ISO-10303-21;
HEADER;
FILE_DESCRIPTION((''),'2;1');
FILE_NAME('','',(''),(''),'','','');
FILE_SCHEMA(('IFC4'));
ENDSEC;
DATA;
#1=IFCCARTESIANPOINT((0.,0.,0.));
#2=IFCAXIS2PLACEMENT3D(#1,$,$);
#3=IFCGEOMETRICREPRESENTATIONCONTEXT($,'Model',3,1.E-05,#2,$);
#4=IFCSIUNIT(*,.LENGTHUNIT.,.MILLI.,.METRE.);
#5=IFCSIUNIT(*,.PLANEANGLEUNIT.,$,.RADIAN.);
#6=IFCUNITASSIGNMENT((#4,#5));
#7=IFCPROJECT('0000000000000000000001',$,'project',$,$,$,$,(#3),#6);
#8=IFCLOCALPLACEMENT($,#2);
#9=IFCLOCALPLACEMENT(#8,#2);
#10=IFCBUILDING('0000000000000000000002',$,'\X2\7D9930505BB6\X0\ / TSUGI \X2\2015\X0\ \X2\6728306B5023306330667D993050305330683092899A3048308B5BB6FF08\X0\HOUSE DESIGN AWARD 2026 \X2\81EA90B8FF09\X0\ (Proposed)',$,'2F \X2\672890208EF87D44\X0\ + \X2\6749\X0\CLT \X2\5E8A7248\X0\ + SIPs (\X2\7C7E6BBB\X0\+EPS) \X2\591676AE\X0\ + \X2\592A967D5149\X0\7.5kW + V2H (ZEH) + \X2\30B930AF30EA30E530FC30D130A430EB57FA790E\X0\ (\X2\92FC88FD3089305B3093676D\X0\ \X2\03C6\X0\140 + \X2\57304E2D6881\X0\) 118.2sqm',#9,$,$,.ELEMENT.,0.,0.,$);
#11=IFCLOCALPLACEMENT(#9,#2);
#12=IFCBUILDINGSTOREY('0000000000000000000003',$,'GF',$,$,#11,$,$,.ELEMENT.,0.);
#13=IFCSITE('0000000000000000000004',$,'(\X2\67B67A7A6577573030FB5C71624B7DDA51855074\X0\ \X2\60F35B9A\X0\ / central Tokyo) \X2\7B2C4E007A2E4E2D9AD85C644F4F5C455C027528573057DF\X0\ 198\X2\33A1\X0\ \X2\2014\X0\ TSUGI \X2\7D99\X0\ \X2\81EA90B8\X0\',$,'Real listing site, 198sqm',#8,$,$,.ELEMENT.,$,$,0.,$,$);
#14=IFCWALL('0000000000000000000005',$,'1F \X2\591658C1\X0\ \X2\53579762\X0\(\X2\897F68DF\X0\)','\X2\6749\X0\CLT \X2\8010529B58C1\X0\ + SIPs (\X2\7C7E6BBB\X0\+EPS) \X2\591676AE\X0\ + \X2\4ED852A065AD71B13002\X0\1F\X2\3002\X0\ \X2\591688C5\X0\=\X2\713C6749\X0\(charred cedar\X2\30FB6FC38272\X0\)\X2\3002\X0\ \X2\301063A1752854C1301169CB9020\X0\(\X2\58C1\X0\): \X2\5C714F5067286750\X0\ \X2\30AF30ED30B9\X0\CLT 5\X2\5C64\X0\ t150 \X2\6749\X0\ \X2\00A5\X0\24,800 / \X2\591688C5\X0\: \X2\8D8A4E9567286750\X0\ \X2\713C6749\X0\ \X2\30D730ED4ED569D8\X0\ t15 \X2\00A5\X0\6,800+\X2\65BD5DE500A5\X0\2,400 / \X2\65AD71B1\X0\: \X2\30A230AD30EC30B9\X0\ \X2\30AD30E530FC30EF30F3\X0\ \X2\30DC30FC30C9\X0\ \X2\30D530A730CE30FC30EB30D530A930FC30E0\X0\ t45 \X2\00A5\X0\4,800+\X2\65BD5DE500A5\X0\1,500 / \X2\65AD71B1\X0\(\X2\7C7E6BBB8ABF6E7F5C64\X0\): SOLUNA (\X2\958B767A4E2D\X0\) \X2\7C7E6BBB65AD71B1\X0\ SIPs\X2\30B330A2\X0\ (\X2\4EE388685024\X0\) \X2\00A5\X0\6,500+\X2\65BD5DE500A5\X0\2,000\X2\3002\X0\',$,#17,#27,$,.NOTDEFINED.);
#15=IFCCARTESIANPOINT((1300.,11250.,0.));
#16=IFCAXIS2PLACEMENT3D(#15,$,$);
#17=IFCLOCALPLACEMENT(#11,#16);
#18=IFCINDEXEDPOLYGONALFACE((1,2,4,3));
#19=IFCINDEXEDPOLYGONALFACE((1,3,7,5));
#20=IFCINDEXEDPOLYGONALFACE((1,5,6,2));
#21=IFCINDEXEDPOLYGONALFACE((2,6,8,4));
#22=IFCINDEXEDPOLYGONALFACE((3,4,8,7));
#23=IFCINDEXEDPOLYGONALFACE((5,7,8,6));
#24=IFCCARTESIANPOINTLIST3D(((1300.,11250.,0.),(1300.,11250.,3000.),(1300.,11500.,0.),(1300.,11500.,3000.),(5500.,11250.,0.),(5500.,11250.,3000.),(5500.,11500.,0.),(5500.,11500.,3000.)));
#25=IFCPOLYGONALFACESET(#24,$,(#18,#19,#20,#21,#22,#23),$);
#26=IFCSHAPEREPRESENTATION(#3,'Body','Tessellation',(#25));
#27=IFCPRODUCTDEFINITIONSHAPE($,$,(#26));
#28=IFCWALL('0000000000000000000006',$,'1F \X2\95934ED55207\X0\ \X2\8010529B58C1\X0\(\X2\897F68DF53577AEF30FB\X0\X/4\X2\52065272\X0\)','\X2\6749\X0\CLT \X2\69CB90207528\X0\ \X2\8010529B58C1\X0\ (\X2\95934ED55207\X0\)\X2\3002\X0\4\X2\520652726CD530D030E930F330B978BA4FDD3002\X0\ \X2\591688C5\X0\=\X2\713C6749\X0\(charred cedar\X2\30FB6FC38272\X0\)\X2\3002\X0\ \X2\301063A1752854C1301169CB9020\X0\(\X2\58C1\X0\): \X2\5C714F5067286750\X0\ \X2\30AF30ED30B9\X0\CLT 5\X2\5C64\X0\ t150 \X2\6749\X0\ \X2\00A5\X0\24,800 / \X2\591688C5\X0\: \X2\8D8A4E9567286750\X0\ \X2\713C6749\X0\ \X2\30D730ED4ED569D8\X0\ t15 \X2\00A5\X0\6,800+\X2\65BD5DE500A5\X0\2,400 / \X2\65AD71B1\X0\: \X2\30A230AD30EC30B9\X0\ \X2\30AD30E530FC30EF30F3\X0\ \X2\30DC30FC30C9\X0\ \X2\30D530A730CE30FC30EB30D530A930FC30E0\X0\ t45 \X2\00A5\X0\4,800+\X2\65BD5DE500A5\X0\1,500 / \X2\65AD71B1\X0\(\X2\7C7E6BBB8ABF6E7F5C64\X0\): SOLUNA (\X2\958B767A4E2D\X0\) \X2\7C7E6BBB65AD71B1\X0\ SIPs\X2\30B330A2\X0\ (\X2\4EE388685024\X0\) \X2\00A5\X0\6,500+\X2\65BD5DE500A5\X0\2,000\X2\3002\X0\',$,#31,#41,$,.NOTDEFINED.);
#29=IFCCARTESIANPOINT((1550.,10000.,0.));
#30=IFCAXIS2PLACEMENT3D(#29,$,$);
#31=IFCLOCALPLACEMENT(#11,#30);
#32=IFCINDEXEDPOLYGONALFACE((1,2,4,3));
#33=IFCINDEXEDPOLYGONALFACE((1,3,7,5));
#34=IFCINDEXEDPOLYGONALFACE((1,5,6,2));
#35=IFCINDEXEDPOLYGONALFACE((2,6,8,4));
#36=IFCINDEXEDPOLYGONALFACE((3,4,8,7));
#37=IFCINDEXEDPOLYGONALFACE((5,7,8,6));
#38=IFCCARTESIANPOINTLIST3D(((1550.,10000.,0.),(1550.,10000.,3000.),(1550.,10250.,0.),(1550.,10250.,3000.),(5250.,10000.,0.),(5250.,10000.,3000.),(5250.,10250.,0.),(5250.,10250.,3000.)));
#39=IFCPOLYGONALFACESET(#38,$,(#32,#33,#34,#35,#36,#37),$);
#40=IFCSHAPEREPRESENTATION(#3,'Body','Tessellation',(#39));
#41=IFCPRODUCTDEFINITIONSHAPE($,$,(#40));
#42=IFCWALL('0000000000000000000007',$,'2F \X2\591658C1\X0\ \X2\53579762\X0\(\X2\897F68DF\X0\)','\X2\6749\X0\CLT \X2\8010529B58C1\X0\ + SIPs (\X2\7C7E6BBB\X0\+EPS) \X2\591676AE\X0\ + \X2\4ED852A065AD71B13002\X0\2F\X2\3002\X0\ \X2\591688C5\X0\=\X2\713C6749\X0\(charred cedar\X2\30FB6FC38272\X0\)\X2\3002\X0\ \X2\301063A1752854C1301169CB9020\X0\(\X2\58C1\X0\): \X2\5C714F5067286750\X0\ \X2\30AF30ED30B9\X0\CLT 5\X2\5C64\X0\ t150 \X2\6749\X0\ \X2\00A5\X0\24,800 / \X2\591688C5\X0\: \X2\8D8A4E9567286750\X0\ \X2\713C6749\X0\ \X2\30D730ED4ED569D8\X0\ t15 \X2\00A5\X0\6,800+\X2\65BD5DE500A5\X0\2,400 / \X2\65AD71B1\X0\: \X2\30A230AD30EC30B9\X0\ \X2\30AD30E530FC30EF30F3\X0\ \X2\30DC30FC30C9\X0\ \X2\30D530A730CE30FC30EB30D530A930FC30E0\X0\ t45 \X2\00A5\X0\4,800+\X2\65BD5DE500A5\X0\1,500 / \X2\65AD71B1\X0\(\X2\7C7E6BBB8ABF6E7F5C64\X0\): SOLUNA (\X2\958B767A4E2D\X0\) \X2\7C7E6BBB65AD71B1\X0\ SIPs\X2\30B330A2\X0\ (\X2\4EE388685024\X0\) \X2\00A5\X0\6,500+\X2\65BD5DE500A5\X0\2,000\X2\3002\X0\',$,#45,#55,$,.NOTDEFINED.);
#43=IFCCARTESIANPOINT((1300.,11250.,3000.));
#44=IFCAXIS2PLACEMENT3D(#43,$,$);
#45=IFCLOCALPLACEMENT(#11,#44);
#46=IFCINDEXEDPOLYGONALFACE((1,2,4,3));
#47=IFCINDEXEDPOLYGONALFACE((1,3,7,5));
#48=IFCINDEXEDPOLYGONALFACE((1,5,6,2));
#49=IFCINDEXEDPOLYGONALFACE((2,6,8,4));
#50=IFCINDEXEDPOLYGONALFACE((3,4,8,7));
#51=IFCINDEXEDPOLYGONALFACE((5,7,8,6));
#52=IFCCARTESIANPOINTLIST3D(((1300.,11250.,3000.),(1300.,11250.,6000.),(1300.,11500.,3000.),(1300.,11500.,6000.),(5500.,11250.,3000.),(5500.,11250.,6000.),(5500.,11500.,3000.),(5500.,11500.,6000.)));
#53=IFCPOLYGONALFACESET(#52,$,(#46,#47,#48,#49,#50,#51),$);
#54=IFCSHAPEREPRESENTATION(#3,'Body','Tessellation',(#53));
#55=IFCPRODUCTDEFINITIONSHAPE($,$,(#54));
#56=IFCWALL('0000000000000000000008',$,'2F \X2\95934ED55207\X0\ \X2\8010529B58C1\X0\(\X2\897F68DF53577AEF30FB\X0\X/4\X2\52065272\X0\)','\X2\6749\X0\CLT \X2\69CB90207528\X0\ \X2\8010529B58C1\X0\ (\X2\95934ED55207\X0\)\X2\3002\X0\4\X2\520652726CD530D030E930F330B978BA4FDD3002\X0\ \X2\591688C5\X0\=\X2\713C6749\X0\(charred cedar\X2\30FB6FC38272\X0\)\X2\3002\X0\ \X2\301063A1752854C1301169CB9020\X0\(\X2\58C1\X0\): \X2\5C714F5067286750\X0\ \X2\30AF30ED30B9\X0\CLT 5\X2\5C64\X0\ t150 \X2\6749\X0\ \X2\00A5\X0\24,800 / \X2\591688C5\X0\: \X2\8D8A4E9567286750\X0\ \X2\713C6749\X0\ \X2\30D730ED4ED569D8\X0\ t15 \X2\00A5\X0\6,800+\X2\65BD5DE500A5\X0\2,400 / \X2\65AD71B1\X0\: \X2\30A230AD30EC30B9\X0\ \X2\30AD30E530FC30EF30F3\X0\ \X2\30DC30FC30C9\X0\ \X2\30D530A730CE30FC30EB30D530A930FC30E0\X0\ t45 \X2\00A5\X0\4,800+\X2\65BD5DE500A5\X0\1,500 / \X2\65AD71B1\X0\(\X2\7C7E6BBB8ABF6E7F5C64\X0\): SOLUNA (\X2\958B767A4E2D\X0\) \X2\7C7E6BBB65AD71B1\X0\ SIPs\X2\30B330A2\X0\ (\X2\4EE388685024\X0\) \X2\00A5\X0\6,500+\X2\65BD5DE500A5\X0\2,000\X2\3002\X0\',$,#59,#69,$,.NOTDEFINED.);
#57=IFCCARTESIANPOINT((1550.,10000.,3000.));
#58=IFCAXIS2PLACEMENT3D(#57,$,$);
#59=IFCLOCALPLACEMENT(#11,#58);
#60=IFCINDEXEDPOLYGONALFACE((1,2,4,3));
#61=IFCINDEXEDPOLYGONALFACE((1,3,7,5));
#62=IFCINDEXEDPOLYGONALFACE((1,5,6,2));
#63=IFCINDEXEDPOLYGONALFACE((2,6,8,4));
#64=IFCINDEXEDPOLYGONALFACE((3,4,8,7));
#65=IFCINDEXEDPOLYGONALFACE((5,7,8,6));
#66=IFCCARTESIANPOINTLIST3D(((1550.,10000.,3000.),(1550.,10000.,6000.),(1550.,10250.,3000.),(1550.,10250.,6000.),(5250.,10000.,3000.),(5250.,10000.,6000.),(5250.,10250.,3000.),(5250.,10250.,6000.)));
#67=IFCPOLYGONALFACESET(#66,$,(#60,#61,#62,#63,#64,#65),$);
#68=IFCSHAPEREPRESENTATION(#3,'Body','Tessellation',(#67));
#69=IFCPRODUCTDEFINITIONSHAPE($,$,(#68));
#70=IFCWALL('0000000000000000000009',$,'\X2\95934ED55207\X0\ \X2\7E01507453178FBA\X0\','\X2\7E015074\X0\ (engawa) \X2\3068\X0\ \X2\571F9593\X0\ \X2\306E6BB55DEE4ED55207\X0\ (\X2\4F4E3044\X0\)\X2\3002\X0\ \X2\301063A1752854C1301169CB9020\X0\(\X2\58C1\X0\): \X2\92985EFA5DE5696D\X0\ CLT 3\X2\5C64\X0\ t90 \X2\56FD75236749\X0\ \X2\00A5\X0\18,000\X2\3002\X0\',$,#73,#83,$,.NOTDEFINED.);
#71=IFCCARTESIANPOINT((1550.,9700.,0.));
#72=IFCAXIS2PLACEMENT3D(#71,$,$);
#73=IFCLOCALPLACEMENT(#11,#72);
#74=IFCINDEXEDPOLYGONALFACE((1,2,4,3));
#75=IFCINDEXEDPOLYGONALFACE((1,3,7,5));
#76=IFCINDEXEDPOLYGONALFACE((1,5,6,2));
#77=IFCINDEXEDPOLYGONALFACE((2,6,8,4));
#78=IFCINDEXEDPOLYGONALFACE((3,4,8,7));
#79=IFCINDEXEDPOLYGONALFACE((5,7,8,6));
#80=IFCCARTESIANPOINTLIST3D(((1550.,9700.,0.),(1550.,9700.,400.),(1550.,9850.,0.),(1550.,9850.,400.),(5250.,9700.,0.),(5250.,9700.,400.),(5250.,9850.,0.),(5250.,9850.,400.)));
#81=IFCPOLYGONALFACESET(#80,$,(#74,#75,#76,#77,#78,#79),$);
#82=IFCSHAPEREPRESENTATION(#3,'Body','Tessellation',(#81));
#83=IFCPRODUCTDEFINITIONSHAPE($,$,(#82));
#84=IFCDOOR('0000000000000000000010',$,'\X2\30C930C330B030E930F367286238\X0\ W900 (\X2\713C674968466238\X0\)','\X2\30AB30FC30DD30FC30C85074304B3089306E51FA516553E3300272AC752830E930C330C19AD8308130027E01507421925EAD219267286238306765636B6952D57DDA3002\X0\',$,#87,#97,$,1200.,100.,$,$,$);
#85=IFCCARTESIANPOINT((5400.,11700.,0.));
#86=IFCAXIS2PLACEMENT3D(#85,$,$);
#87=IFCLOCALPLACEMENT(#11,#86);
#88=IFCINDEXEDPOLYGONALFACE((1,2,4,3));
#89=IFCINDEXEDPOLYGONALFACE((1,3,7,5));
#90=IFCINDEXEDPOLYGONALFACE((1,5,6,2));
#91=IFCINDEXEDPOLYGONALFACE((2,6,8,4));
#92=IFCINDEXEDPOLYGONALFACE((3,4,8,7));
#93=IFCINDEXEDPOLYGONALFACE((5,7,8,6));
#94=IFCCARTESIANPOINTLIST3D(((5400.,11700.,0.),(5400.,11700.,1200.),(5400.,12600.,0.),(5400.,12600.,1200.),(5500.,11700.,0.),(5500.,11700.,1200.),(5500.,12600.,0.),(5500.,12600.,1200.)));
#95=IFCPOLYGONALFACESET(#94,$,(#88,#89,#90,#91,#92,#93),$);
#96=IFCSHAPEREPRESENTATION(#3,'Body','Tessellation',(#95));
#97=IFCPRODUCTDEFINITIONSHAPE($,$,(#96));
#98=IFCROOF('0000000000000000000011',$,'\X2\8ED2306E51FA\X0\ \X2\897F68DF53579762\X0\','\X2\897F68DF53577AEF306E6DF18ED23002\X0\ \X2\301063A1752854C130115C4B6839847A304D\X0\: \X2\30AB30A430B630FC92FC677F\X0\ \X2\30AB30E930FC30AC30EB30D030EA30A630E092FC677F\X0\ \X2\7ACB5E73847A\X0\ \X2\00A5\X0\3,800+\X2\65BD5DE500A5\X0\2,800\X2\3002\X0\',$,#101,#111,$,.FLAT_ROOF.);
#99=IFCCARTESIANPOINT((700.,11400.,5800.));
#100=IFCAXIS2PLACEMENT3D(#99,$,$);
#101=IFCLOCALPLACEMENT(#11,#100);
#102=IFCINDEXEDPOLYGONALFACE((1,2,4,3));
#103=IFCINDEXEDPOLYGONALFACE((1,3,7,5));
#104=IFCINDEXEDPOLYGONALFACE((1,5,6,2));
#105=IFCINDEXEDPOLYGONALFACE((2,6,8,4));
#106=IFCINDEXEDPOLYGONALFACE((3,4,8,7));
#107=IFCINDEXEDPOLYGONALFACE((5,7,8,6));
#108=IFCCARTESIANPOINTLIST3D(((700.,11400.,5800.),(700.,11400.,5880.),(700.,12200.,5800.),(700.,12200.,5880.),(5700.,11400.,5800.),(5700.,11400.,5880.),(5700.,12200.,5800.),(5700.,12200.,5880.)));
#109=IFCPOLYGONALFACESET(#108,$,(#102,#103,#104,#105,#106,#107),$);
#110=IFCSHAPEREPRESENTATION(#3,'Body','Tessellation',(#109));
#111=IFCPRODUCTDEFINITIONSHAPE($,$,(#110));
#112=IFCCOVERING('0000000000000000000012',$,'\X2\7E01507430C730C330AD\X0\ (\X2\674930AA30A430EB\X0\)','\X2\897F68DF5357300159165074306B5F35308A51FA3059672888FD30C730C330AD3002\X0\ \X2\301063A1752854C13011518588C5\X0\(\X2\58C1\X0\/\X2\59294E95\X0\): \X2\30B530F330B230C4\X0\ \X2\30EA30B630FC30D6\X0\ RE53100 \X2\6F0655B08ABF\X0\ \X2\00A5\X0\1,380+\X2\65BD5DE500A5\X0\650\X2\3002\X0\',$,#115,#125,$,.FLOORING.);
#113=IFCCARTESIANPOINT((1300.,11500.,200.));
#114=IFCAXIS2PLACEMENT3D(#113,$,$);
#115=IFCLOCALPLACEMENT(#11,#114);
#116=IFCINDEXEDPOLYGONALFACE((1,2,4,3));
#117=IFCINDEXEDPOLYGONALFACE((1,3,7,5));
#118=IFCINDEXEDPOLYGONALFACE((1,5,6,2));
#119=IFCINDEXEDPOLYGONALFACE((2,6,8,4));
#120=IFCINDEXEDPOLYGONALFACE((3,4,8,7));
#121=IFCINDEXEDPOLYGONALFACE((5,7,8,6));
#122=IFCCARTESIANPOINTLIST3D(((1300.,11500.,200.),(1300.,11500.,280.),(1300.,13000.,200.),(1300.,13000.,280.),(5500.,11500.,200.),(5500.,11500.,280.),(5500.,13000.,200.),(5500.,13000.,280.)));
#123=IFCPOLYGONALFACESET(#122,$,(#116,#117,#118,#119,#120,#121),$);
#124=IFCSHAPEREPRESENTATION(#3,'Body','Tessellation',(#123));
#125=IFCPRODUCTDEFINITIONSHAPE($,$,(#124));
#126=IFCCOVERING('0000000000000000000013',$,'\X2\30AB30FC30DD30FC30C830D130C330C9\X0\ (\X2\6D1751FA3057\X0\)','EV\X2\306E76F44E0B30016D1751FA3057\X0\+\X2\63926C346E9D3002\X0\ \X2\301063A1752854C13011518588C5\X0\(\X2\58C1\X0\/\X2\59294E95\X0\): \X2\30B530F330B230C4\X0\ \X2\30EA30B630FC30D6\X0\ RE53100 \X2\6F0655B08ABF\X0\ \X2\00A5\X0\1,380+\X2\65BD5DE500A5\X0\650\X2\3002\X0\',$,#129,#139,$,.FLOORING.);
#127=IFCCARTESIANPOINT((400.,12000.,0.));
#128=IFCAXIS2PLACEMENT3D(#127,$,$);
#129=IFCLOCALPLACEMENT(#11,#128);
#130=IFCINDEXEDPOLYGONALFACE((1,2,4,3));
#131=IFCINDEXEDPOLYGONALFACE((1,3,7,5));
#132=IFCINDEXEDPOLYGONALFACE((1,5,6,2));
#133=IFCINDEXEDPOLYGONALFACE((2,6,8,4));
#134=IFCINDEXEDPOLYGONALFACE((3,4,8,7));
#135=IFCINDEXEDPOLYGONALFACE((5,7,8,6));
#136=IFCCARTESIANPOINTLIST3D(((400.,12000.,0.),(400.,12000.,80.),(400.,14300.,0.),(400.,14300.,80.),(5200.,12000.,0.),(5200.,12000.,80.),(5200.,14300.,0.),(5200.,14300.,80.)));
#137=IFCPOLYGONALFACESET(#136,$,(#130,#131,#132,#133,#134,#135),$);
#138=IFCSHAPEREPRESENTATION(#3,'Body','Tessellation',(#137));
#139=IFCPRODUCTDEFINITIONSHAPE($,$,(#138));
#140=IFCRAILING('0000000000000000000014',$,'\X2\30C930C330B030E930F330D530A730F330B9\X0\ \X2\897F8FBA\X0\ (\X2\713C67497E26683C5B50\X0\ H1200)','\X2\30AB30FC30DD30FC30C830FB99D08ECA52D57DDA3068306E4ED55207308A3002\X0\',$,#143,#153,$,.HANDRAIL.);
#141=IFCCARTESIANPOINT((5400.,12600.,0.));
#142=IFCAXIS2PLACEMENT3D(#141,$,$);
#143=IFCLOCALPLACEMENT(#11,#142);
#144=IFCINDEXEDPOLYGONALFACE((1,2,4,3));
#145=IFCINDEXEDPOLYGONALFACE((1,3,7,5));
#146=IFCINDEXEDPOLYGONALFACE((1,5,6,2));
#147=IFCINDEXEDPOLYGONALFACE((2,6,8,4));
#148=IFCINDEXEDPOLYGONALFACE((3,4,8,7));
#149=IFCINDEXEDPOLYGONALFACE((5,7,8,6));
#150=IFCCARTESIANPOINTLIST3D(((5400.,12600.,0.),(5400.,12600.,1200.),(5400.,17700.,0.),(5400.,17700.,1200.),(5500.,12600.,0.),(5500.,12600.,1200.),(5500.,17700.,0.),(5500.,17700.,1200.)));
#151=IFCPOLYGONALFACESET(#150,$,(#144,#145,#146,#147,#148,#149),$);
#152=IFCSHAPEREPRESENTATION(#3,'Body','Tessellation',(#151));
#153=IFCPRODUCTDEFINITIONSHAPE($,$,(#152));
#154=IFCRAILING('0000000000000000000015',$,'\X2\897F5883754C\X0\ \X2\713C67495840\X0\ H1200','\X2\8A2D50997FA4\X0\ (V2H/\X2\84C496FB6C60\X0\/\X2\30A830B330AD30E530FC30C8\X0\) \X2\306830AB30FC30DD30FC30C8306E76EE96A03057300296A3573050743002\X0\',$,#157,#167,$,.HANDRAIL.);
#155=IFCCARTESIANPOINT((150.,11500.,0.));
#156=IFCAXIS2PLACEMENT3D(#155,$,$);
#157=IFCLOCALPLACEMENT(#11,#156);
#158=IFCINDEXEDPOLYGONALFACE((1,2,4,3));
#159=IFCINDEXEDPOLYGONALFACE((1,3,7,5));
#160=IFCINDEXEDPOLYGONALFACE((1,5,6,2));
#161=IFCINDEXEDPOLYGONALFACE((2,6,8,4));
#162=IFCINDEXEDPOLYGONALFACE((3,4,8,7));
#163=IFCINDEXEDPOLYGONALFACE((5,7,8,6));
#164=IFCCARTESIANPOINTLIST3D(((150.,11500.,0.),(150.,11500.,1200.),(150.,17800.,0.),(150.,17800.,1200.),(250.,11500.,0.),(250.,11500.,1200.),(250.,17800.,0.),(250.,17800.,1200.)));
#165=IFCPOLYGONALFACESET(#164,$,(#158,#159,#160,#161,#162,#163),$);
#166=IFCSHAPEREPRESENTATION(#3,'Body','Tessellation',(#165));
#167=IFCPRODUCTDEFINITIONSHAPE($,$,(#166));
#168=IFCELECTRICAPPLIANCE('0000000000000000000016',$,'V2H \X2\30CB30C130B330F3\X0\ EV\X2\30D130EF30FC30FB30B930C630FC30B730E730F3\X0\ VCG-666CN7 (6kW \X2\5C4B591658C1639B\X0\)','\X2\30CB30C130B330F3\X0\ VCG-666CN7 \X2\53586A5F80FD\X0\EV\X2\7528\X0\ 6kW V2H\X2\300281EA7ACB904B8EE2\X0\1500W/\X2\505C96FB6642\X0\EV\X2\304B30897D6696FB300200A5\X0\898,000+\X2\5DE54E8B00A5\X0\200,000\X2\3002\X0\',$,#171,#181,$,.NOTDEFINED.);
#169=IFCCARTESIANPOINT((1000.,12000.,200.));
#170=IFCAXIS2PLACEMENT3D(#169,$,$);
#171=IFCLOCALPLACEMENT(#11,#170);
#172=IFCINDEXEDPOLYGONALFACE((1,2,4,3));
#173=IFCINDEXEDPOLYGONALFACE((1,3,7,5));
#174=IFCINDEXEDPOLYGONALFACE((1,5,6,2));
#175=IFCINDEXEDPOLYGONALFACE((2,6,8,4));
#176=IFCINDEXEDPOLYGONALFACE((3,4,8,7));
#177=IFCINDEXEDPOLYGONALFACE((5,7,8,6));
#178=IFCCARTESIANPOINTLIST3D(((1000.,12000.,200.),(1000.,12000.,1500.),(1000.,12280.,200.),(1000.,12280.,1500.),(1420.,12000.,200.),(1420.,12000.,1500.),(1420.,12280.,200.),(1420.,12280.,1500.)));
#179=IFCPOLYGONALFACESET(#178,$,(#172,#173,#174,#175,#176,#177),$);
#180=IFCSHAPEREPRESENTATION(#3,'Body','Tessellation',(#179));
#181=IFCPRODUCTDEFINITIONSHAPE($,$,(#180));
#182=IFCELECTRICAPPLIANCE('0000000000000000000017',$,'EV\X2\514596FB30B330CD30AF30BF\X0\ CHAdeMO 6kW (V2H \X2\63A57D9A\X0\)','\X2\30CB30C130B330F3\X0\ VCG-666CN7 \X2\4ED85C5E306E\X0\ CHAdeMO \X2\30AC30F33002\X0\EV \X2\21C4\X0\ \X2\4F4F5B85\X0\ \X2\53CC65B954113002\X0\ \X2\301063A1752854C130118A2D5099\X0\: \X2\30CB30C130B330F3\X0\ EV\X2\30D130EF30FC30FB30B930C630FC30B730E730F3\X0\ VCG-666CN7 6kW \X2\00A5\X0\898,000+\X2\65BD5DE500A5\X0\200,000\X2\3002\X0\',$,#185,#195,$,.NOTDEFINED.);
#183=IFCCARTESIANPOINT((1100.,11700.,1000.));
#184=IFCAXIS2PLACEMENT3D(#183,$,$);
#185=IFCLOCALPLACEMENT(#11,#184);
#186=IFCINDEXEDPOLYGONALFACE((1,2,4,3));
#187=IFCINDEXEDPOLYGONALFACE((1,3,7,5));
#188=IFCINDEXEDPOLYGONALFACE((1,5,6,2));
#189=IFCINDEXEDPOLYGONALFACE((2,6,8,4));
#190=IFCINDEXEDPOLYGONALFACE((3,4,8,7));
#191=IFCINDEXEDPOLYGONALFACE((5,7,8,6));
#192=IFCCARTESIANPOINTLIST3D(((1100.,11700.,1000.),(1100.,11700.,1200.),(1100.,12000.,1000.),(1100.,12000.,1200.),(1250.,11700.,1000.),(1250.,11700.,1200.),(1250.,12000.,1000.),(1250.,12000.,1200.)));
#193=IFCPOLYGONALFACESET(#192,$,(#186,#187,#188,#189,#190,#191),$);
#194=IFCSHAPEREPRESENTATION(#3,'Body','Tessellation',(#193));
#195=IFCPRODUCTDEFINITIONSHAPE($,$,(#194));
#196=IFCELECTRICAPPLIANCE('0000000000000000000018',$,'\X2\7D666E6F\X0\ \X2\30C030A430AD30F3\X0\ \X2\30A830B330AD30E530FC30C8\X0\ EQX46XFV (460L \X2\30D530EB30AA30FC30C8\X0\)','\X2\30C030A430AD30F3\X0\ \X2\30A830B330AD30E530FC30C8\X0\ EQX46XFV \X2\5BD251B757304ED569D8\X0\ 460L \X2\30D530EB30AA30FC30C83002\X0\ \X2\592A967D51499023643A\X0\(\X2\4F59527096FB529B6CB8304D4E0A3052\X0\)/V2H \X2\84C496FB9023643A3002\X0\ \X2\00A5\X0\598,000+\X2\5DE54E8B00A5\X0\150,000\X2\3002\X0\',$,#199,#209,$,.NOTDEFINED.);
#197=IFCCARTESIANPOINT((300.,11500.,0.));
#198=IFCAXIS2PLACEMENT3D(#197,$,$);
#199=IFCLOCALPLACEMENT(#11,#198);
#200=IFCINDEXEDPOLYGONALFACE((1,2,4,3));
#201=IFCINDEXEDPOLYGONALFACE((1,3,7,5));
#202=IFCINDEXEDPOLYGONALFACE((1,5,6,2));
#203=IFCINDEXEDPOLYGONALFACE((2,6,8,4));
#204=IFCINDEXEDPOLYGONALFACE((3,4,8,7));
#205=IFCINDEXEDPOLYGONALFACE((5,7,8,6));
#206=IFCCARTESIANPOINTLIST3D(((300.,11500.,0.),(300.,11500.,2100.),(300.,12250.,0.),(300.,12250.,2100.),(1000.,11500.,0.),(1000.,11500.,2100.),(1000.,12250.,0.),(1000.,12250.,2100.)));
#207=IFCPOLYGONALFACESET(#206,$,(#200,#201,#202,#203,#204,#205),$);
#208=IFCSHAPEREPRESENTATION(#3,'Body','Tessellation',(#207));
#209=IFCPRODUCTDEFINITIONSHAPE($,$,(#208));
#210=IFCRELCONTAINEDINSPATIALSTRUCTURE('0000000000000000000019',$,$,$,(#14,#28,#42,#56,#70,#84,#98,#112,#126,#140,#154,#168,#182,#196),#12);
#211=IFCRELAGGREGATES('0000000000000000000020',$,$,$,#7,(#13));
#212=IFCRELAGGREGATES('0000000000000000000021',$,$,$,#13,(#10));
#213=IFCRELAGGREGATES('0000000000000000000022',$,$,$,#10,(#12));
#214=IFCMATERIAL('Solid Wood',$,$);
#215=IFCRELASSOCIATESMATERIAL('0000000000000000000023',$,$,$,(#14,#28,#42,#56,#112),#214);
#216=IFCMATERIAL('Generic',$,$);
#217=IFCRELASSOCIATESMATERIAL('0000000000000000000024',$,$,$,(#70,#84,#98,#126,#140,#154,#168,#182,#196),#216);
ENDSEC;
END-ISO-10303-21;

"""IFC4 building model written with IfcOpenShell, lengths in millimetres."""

from ifc_helpers import new_model, si_unit, frame, frame_2d, origin, place, context, project, spatial, rectangle, extrude, material, element, save


model = new_model("IFC4")

# Units and contexts
model_context = context("Model", 3, precision=1e-05, world=origin())
ifc_project = project(units=[si_unit("LENGTHUNIT", "METRE", prefix="MILLI"), si_unit("PLANEANGLEUNIT", "RADIAN")], contexts=[model_context])

# Site, building, storey
site_placement = place(None, origin())
site = spatial("IfcSite", under=ifc_project, at=site_placement, Name="(架空敷地・山手線内側 想定 / central Tokyo) 第一種中高層住居専用地域 198㎡ — TSUGI 継 自邸", ObjectType="Real listing site, 198sqm", CompositionType="ELEMENT", RefElevation=0.0)
building_placement = place(site_placement, origin())
building = spatial("IfcBuilding", under=site, at=building_placement, Name="継ぐ家 / TSUGI ― 木に倣って継ぐことを覚える家（HOUSE DESIGN AWARD 2026 自邸） (Proposed)", ObjectType="2F 木造軸組 + 杉CLT 床版 + SIPs (籾殻+EPS) 外皮 + 太陽光7.5kW + V2H (ZEH) + スクリューパイル基礎 (鋼製らせん杭 φ140 + 地中梁) 118.2sqm", CompositionType="ELEMENT", ElevationOfRefHeight=0.0, ElevationOfTerrain=0.0)
storey_placement = place(building_placement, origin())
storey = spatial("IfcBuildingStorey", under=building, at=storey_placement, Name="GF", CompositionType="ELEMENT", Elevation=0.0)

# Shared definitions
ifc_material_1 = material(Name="Generic")

# Walls
ifc_material_2 = material(Name="Solid Wood")
wall_1_placement = place(storey_placement, frame((1300.0, 11250.0, 0.0)))
element("IfcWall", 1, at=wall_1_placement, inside=storey, material=ifc_material_2, Name="1F 外壁 南面(西棟)", Description="杉CLT 耐力壁 + SIPs (籾殻+EPS) 外皮 + 付加断熱。1F。 外装=焼杉(charred cedar・濃色)。 【採用品】構造(壁): 山佐木材 クロスCLT 5層 t150 杉 ¥24,800 / 外装: 越井木材 焼杉 プロ仕様 t15 ¥6,800+施工¥2,400 / 断熱: アキレス キューワン ボード フェノールフォーム t45 ¥4,800+施工¥1,500 / 断熱(籾殻調湿層): SOLUNA (開発中) 籾殻断熱 SIPsコア (代表値) ¥6,500+施工¥2,000。", PredefinedType="NOTDEFINED", context=model_context, shape_type="SweptSolid", body=[
    extrude(rectangle(XDim=4200.0, YDim=250.0, at=frame_2d((2100.0, 125.0))), frame((1300.0, 11250.0, 0.0)), (0.0, 0.0, 1.0), 3000.0),
])
wall_2_placement = place(storey_placement, frame((1550.0, 10000.0, 0.0)))
element("IfcWall", 2, at=wall_2_placement, inside=storey, material=ifc_material_2, Name="1F 間仕切 耐力壁(西棟南端・X/4分割)", Description="杉CLT 構造用 耐力壁 (間仕切)。4分割法バランス確保。 外装=焼杉(charred cedar・濃色)。 【採用品】構造(壁): 山佐木材 クロスCLT 5層 t150 杉 ¥24,800 / 外装: 越井木材 焼杉 プロ仕様 t15 ¥6,800+施工¥2,400 / 断熱: アキレス キューワン ボード フェノールフォーム t45 ¥4,800+施工¥1,500 / 断熱(籾殻調湿層): SOLUNA (開発中) 籾殻断熱 SIPsコア (代表値) ¥6,500+施工¥2,000。", PredefinedType="NOTDEFINED", context=model_context, shape_type="SweptSolid", body=[
    extrude(rectangle(XDim=3700.0, YDim=250.0, at=frame_2d((1850.0, 125.0))), frame((1550.0, 10000.0, 0.0)), (0.0, 0.0, 1.0), 3000.0),
])
wall_3_placement = place(storey_placement, frame((1300.0, 11250.0, 3000.0)))
element("IfcWall", 3, at=wall_3_placement, inside=storey, material=ifc_material_2, Name="2F 外壁 南面(西棟)", Description="杉CLT 耐力壁 + SIPs (籾殻+EPS) 外皮 + 付加断熱。2F。 外装=焼杉(charred cedar・濃色)。 【採用品】構造(壁): 山佐木材 クロスCLT 5層 t150 杉 ¥24,800 / 外装: 越井木材 焼杉 プロ仕様 t15 ¥6,800+施工¥2,400 / 断熱: アキレス キューワン ボード フェノールフォーム t45 ¥4,800+施工¥1,500 / 断熱(籾殻調湿層): SOLUNA (開発中) 籾殻断熱 SIPsコア (代表値) ¥6,500+施工¥2,000。", PredefinedType="NOTDEFINED", context=model_context, shape_type="SweptSolid", body=[
    extrude(rectangle(XDim=4200.0, YDim=250.0, at=frame_2d((2100.0, 125.0))), frame((1300.0, 11250.0, 3000.0)), (0.0, 0.0, 1.0), 3000.0),
])
wall_4_placement = place(storey_placement, frame((1550.0, 10000.0, 3000.0)))
element("IfcWall", 4, at=wall_4_placement, inside=storey, material=ifc_material_2, Name="2F 間仕切 耐力壁(西棟南端・X/4分割)", Description="杉CLT 構造用 耐力壁 (間仕切)。4分割法バランス確保。 外装=焼杉(charred cedar・濃色)。 【採用品】構造(壁): 山佐木材 クロスCLT 5層 t150 杉 ¥24,800 / 外装: 越井木材 焼杉 プロ仕様 t15 ¥6,800+施工¥2,400 / 断熱: アキレス キューワン ボード フェノールフォーム t45 ¥4,800+施工¥1,500 / 断熱(籾殻調湿層): SOLUNA (開発中) 籾殻断熱 SIPsコア (代表値) ¥6,500+施工¥2,000。", PredefinedType="NOTDEFINED", context=model_context, shape_type="SweptSolid", body=[
    extrude(rectangle(XDim=3700.0, YDim=250.0, at=frame_2d((1850.0, 125.0))), frame((1550.0, 10000.0, 3000.0)), (0.0, 0.0, 1.0), 3000.0),
])
wall_5_placement = place(storey_placement, frame((1550.0, 9700.0, 0.0)))
element("IfcWall", 5, at=wall_5_placement, inside=storey, material=ifc_material_1, Name="間仕切 縁側北辺", Description="縁側 (engawa) と 土間 の段差仕切 (低い)。 【採用品】構造(壁): 銘建工業 CLT 3層 t90 国産杉 ¥18,000。", PredefinedType="NOTDEFINED", context=model_context, shape_type="SweptSolid", body=[
    extrude(rectangle(XDim=3700.0, YDim=150.0, at=frame_2d((1850.0, 75.0))), frame((1550.0, 9700.0, 0.0)), (0.0, 0.0, 1.0), 400.0),
])

# Door
door_placement = place(storey_placement, frame((5400.0, 11700.0, 0.0)))
element("IfcDoor", 6, at=door_placement, inside=storey, material=ifc_material_1, Name="ドッグラン木戸 W900 (焼杉框戸)", Description="カーポート側からの出入口。犬用ラッチ高め。縁側→庭→木戸で散歩動線。", OverallHeight=1200.0, OverallWidth=100.0, context=model_context, shape_type="SweptSolid", body=[
    extrude(rectangle(XDim=100.0, YDim=900.0, at=frame_2d((50.0, 450.0))), frame((5400.0, 11700.0, 0.0)), (0.0, 0.0, 1.0), 1200.0),
])

# Roof
roof_placement = place(storey_placement, frame((700.0, 11400.0, 5800.0)))
element("IfcRoof", 7, at=roof_placement, inside=storey, material=ifc_material_1, Name="軒の出 西棟南面", Description="西棟南端の深軒。 【採用品】屋根葺き: カイザー鋼板 カラーガルバリウム鋼板 立平葺 ¥3,800+施工¥2,800。", PredefinedType="FLAT_ROOF", context=model_context, shape_type="SweptSolid", body=[
    extrude(rectangle(XDim=5000.0, YDim=800.0, at=frame_2d((2500.0, 400.0))), frame((700.0, 11400.0, 5800.0)), (0.0, 0.0, 1.0), 80.0),
])

# Coverings
covering_1_placement = place(storey_placement, frame((1300.0, 11500.0, 200.0)))
element("IfcCovering", 8, at=covering_1_placement, inside=storey, material=ifc_material_2, Name="縁側デッキ (杉オイル)", Description="西棟南、外側に張り出す木製デッキ。 【採用品】内装(壁/天井): サンゲツ リザーブ RE53100 漆喰調 ¥1,380+施工¥650。", PredefinedType="FLOORING", context=model_context, shape_type="SweptSolid", body=[
    extrude(rectangle(XDim=4200.0, YDim=1500.0, at=frame_2d((2100.0, 750.0))), frame((1300.0, 11500.0, 200.0)), (0.0, 0.0, 1.0), 80.0),
])
covering_2_placement = place(storey_placement, frame((400.0, 12000.0, 0.0)))
element("IfcCovering", 9, at=covering_2_placement, inside=storey, material=ifc_material_1, Name="カーポートパッド (洗出し)", Description="EVの直下、洗出し+排水溝。 【採用品】内装(壁/天井): サンゲツ リザーブ RE53100 漆喰調 ¥1,380+施工¥650。", PredefinedType="FLOORING", context=model_context, shape_type="SweptSolid", body=[
    extrude(rectangle(XDim=4800.0, YDim=2300.0, at=frame_2d((2400.0, 1150.0))), frame((400.0, 12000.0, 0.0)), (0.0, 0.0, 1.0), 80.0),
])

# Railings
railing_1_placement = place(storey_placement, frame((5400.0, 12600.0, 0.0)))
element("IfcRailing", 10, at=railing_1_placement, inside=storey, material=ifc_material_1, Name="ドッグランフェンス 西辺 (焼杉縦格子 H1200)", Description="カーポート・駐車動線との仕切り。", PredefinedType="HANDRAIL", context=model_context, shape_type="SweptSolid", body=[
    extrude(rectangle(XDim=100.0, YDim=5100.0, at=frame_2d((50.0, 2550.0))), frame((5400.0, 12600.0, 0.0)), (0.0, 0.0, 1.0), 1200.0),
])
railing_2_placement = place(storey_placement, frame((150.0, 11500.0, 0.0)))
element("IfcRailing", 11, at=railing_2_placement, inside=storey, material=ifc_material_1, Name="西境界 焼杉塀 H1200", Description="設備群 (V2H/蓄電池/エコキュート) とカーポートの目隠し。隣地側。", PredefinedType="HANDRAIL", context=model_context, shape_type="SweptSolid", body=[
    extrude(rectangle(XDim=100.0, YDim=6300.0, at=frame_2d((50.0, 3150.0))), frame((150.0, 11500.0, 0.0)), (0.0, 0.0, 1.0), 1200.0),
])

# Electric appliances
electric_appliance_1_placement = place(storey_placement, frame((1000.0, 12000.0, 200.0)))
element("IfcElectricAppliance", 12, at=electric_appliance_1_placement, inside=storey, material=ifc_material_1, Name="V2H ニチコン EVパワー・ステーション VCG-666CN7 (6kW 屋外壁掛)", Description="ニチコン VCG-666CN7 単機能EV用 6kW V2H。自立運転1500W/停電時EVから給電。¥898,000+工事¥200,000。", PredefinedType="NOTDEFINED", context=model_context, shape_type="SweptSolid", body=[
    extrude(rectangle(XDim=420.0, YDim=280.0, at=frame_2d((210.0, 140.0))), frame((1000.0, 12000.0, 200.0)), (0.0, 0.0, 1.0), 1300.0),
])
electric_appliance_2_placement = place(storey_placement, frame((1100.0, 11700.0, 1000.0)))
element("IfcElectricAppliance", 13, at=electric_appliance_2_placement, inside=storey, material=ifc_material_1, Name="EV充電コネクタ CHAdeMO 6kW (V2H 接続)", Description="ニチコン VCG-666CN7 付属の CHAdeMO ガン。EV ⇄ 住宅 双方向。 【採用品】設備: ニチコン EVパワー・ステーション VCG-666CN7 6kW ¥898,000+施工¥200,000。", PredefinedType="NOTDEFINED", context=model_context, shape_type="SweptSolid", body=[
    extrude(rectangle(XDim=150.0, YDim=300.0, at=frame_2d((75.0, 150.0))), frame((1100.0, 11700.0, 1000.0)), (0.0, 0.0, 1.0), 200.0),
])
electric_appliance_3_placement = place(storey_placement, frame((300.0, 11500.0, 0.0)))
element("IfcElectricAppliance", 14, at=electric_appliance_3_placement, inside=storey, material=ifc_material_1, Name="給湯 ダイキン エコキュート EQX46XFV (460L フルオート)", Description="ダイキン エコキュート EQX46XFV 寒冷地仕様 460L フルオート。 太陽光連携(余剰電力沸き上げ)/V2H 蓄電連携。 ¥598,000+工事¥150,000。", PredefinedType="NOTDEFINED", context=model_context, shape_type="SweptSolid", body=[
    extrude(rectangle(XDim=700.0, YDim=750.0, at=frame_2d((350.0, 375.0))), frame((300.0, 11500.0, 0.0)), (0.0, 0.0, 1.0), 2100.0),
])

save(model, "model.ifc")
